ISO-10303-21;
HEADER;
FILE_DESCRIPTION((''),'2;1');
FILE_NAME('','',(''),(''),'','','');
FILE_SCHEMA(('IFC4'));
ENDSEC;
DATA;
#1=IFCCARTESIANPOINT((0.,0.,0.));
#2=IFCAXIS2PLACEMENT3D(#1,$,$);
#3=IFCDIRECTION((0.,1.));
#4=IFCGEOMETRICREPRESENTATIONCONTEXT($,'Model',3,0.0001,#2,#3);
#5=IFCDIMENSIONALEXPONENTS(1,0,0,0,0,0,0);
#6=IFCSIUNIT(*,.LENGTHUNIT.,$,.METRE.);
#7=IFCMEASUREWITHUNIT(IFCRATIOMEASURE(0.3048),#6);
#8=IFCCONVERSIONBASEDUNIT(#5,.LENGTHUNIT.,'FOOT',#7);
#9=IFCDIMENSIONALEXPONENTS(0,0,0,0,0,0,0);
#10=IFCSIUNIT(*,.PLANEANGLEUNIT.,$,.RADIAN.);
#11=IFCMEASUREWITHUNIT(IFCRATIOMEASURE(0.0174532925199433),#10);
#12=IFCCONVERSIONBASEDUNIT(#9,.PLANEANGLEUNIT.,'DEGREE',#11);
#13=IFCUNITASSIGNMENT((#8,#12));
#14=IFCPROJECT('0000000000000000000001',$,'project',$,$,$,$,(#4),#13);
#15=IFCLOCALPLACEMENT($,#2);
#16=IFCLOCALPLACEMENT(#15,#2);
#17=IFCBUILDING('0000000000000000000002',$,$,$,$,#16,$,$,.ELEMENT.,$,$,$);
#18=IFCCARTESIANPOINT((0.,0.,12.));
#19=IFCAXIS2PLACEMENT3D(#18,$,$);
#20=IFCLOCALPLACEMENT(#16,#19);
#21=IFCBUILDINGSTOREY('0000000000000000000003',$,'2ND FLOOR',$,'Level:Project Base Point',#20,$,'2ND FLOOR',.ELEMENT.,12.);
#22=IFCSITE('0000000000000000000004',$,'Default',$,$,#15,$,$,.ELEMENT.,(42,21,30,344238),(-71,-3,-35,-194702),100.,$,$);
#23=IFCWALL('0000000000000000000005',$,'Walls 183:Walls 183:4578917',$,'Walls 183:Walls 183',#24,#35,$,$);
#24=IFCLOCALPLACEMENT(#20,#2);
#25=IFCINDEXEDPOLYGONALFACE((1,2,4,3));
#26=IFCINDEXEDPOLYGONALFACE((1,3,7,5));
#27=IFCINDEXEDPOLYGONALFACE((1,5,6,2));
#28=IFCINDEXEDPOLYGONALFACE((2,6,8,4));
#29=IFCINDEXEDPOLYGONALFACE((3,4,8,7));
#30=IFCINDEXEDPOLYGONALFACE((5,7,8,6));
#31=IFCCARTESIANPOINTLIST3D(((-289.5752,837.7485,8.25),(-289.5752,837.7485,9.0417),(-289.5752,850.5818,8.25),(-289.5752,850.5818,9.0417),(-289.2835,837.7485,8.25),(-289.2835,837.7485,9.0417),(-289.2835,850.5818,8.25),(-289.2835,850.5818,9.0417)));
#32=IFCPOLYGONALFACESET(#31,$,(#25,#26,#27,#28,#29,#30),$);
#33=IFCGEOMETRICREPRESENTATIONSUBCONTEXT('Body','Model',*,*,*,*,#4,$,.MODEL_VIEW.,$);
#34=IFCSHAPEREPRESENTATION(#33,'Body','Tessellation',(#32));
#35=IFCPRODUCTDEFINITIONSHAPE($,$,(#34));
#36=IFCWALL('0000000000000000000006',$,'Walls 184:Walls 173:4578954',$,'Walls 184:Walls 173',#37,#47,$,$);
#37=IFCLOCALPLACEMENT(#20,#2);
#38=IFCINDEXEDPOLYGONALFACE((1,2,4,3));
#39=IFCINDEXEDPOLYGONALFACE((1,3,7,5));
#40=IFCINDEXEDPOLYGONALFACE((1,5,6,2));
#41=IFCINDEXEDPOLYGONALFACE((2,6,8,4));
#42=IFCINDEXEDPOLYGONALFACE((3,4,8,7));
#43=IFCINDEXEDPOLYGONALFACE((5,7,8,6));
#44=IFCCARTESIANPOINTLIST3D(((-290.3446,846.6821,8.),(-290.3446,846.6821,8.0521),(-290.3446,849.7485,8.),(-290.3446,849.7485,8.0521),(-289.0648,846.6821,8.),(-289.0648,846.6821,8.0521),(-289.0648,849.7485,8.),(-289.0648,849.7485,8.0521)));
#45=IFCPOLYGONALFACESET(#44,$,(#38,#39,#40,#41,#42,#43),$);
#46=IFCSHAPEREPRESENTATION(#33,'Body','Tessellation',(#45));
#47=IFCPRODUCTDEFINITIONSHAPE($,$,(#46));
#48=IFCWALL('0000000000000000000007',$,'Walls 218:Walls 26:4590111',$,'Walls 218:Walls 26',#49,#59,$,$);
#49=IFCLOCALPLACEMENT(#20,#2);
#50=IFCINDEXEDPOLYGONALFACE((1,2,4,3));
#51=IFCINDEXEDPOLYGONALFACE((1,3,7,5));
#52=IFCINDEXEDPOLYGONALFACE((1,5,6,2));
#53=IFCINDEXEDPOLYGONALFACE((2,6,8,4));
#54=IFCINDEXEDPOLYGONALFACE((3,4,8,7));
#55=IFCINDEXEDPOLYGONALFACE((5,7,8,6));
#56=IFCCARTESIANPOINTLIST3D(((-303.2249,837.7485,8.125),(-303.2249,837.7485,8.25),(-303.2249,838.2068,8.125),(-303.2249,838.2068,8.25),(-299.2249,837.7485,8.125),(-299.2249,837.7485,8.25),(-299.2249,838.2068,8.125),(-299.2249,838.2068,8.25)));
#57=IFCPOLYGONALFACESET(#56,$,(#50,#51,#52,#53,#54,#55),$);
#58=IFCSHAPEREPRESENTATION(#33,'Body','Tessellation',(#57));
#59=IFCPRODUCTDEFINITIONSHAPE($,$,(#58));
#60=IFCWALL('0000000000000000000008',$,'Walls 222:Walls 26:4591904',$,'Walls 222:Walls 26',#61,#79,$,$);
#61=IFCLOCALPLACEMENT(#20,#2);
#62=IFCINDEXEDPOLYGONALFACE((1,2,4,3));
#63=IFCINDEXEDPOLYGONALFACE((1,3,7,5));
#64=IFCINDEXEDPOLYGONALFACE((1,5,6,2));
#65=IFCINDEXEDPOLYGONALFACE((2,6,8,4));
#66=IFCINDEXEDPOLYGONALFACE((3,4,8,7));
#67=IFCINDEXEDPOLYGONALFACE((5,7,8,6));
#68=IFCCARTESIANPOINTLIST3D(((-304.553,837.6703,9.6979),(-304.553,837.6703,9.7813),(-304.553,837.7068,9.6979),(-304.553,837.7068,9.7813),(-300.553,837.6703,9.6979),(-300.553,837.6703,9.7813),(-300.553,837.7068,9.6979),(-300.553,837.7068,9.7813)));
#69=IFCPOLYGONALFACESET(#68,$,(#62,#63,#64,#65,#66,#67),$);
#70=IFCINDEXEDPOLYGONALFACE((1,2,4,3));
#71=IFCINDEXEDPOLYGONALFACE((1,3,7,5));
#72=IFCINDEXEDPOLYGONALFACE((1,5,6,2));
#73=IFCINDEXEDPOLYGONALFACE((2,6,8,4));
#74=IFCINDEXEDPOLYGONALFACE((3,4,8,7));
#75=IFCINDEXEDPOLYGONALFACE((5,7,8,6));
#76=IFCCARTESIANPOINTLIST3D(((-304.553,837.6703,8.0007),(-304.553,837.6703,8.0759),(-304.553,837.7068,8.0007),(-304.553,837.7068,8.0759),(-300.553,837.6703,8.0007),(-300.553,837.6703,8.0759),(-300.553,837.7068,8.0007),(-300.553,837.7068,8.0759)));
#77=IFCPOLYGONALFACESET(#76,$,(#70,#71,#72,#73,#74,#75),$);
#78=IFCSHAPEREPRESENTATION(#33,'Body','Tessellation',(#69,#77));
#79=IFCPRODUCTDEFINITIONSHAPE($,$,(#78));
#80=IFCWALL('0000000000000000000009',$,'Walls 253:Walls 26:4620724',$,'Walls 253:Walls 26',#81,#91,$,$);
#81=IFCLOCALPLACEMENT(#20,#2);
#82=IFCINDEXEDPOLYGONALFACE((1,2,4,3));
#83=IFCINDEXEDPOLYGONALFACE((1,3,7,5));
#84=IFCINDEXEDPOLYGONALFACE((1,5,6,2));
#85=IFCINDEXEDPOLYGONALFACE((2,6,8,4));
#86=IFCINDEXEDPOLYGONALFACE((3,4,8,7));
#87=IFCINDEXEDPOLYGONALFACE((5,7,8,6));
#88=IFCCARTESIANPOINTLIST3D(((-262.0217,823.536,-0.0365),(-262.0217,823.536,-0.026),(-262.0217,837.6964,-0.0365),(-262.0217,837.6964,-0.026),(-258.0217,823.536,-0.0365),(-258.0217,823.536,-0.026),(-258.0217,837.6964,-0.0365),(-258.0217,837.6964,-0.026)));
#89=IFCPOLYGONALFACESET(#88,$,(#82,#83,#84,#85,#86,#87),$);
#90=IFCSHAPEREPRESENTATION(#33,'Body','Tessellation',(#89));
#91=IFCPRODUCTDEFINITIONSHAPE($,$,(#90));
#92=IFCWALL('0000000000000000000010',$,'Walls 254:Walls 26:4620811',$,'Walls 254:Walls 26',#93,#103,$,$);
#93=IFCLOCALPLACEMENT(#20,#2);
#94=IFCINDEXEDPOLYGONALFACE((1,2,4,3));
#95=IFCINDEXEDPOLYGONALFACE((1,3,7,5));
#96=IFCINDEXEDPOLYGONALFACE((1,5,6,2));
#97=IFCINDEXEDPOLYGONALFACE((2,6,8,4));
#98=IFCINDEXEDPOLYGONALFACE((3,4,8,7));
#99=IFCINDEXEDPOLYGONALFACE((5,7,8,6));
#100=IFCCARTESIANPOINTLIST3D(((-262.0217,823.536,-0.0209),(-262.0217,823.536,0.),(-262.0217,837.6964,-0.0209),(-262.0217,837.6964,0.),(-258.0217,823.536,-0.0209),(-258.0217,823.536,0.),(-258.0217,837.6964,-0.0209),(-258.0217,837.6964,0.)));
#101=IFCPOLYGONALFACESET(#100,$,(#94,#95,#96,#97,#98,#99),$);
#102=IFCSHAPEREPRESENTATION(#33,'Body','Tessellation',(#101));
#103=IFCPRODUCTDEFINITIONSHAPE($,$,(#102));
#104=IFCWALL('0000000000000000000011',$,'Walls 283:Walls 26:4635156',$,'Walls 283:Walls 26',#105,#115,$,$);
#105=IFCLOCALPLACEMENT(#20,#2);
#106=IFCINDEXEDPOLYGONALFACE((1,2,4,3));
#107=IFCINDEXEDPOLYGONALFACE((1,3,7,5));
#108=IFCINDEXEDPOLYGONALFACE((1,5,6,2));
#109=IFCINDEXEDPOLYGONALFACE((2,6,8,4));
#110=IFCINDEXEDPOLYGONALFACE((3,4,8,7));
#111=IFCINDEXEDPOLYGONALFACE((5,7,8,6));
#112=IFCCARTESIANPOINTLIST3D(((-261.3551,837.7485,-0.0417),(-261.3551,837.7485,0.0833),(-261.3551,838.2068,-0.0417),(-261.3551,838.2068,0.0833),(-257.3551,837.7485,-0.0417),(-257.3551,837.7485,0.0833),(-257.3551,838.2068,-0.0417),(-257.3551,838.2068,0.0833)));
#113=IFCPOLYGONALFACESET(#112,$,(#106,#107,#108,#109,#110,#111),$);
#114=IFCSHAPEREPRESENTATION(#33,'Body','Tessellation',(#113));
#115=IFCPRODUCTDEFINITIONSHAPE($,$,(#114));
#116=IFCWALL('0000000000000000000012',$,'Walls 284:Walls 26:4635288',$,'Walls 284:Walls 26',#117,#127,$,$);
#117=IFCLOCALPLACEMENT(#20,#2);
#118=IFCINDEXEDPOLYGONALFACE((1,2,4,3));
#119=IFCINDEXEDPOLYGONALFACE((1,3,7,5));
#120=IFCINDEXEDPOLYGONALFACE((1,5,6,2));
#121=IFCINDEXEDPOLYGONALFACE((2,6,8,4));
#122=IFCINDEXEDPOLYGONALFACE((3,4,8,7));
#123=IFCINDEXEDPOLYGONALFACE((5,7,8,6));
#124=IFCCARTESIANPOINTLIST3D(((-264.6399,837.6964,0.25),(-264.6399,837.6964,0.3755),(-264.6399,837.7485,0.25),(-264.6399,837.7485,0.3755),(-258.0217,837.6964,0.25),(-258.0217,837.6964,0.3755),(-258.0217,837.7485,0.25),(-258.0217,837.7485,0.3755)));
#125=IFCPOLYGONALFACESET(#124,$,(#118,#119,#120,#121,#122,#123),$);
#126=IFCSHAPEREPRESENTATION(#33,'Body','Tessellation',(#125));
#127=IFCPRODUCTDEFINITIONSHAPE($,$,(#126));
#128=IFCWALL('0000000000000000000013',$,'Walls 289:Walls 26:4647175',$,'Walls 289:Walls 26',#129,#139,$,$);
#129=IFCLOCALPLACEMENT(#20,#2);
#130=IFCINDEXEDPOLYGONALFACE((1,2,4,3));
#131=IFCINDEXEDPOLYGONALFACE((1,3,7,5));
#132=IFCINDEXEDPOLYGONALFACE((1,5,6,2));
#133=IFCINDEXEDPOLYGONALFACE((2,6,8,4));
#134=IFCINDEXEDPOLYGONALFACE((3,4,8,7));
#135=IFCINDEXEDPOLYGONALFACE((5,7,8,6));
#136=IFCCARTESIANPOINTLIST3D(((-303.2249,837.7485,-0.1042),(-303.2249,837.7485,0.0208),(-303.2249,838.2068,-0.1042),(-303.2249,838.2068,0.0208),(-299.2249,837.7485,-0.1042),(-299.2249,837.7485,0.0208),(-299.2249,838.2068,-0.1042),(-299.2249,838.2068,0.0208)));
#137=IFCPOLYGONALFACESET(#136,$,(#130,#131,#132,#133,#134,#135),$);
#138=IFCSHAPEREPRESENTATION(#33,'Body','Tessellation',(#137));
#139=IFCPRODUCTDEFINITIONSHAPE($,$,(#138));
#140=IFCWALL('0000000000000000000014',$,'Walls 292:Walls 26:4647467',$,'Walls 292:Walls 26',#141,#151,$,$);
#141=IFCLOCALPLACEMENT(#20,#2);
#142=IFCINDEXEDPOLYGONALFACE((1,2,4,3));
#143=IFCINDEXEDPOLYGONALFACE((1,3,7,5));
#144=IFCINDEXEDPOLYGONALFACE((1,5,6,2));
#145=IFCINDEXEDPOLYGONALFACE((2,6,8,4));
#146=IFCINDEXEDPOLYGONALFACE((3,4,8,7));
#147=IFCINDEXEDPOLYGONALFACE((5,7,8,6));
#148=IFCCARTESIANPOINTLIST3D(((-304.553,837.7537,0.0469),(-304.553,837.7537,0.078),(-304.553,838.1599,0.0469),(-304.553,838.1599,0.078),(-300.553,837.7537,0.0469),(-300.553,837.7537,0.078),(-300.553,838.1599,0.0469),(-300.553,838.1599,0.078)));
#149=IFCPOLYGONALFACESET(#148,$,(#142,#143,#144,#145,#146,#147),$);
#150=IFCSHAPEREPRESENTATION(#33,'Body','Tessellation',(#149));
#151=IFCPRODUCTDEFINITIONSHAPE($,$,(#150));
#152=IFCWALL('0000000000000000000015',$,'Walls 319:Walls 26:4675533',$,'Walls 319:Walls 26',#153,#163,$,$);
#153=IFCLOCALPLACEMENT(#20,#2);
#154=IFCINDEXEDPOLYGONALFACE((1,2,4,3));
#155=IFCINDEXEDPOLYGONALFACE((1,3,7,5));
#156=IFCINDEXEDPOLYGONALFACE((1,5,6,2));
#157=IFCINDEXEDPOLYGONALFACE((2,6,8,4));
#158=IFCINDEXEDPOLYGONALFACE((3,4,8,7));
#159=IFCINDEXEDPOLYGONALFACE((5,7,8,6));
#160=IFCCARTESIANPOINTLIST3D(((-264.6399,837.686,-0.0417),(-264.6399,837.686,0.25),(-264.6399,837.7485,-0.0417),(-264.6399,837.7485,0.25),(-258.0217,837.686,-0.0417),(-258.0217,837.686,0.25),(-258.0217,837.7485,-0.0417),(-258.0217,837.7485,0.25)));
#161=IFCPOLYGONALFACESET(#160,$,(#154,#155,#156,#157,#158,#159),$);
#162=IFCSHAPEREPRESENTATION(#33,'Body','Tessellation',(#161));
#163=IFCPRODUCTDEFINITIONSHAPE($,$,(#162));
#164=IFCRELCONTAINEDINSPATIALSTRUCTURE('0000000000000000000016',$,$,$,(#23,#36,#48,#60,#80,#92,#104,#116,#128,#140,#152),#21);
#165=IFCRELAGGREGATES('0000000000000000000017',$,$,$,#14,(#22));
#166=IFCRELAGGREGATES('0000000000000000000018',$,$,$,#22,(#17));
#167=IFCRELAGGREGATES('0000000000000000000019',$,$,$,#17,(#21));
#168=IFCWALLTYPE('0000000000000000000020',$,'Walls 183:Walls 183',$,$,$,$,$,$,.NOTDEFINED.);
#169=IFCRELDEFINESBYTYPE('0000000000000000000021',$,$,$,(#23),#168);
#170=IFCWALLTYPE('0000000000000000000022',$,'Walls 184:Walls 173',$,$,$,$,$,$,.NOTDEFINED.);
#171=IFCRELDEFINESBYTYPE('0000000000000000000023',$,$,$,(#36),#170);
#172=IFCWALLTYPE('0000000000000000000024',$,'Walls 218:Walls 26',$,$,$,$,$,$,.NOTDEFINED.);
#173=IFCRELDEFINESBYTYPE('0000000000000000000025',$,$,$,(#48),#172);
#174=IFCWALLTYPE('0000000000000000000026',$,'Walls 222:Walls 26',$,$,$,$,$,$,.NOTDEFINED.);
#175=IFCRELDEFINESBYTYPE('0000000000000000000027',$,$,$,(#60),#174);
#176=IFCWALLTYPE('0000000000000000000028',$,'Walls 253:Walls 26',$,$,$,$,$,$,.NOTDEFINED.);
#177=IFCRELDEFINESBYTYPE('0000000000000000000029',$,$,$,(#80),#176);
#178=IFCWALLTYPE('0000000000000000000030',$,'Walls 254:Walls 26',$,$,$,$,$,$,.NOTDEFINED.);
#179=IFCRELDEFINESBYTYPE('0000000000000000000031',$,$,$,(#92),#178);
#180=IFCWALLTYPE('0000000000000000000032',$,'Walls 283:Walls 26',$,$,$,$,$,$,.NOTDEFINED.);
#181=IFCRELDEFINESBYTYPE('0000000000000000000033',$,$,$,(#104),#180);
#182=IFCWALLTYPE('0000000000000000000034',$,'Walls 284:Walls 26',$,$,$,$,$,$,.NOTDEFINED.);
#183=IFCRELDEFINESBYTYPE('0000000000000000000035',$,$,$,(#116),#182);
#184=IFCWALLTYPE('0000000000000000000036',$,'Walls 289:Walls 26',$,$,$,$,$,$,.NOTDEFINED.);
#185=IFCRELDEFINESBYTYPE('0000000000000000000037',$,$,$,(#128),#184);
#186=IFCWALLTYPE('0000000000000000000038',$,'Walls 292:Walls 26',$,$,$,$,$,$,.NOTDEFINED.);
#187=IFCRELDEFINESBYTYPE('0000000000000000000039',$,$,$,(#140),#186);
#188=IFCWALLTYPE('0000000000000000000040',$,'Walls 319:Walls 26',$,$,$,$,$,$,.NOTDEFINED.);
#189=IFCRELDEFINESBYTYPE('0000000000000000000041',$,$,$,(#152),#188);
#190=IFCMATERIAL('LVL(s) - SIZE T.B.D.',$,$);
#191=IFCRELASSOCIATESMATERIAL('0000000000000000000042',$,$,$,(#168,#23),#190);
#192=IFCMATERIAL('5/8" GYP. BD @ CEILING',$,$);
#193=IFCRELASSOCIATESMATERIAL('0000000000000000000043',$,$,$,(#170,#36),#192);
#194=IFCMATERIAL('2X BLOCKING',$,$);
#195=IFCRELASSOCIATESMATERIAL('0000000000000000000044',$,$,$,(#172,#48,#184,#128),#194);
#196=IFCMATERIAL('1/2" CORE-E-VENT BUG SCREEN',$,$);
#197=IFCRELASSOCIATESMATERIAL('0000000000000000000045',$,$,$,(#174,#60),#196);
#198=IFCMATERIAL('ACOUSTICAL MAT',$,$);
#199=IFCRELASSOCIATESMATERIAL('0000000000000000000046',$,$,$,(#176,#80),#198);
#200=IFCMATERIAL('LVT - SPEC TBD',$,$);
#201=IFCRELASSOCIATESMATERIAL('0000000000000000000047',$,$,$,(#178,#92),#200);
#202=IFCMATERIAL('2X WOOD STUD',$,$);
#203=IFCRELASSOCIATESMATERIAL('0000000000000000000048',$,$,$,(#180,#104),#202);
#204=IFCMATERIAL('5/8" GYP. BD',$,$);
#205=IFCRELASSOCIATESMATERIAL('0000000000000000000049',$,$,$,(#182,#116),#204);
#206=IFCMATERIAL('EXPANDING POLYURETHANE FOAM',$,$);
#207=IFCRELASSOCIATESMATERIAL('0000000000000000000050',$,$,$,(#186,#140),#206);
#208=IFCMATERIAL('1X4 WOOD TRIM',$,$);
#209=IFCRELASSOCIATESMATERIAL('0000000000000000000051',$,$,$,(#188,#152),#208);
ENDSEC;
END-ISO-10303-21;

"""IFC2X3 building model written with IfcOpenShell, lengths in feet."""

from ifc_helpers import new_model, entity, si_unit, converted_unit, direction, frame, frame_2d, origin, origin_2d_with_axis, place, context, subcontext, project, spatial, rectangle, extrude, material, type_object, element, save


model = new_model("IFC2X3")

# Units and contexts
model_context = context("Model", 3, precision=0.0001, world=origin(), true_north=direction((0.0, 1.0)))
body_context = subcontext(model_context, "Body", "Model", "MODEL_VIEW")
ifc_project = project(units=[converted_unit("LENGTHUNIT", "FOOT", entity("IfcRatioMeasure", 0.3048), si_unit("LENGTHUNIT", "METRE"), dimensions=[1, 0, 0, 0, 0, 0, 0]), converted_unit("PLANEANGLEUNIT", "DEGREE", entity("IfcRatioMeasure", 0.0174532925199433), si_unit("PLANEANGLEUNIT", "RADIAN"), dimensions=[0, 0, 0, 0, 0, 0, 0])], contexts=[model_context])

# Site, building, storey
site_placement = place(None, origin())
site = spatial("IfcSite", under=ifc_project, at=site_placement, Name="Default", CompositionType="ELEMENT", RefLatitude=(42, 21, 30, 344238), RefLongitude=(-71, -3, -35, -194702), RefElevation=100.0)
building_placement = place(site_placement, origin())
building = spatial("IfcBuilding", under=site, at=building_placement, CompositionType="ELEMENT")
storey_placement = place(building_placement, frame((0.0, 0.0, 12.0)))
storey = spatial("IfcBuildingStorey", under=building, at=storey_placement, Name="2ND FLOOR", ObjectType="Level:Project Base Point", LongName="2ND FLOOR", CompositionType="ELEMENT", Elevation=12.0)

# Walls
ifc_material_1 = material(Name="EXPANDING POLYURETHANE FOAM")
ifc_material_2 = material(Name="LVL(s) - SIZE T.B.D.")
ifc_material_3 = material(Name="2X BLOCKING")
wall_type_1 = type_object("IfcWallType", Name="Walls 183:Walls 183", PredefinedType="NOTDEFINED", material=ifc_material_2)
wall_1_placement = place(storey_placement, frame((-289.5752, 837.7485, 8.25), z_axis=(0.0, 0.0, 1.0), x_axis=(0.0, 1.0, 0.0)))
element("IfcWall", 1, at=wall_1_placement, inside=storey, type_object=wall_type_1, material=ifc_material_2, Name="Walls 183:Walls 183:4578917", ObjectType="Walls 183:Walls 183", context=body_context, shape_type="SweptSolid", body=[
    extrude(rectangle(XDim=12.8333, YDim=0.2917, at=frame_2d((0.0, 0.0), x_axis=(1.0, 0.0))), frame((6.4167, -0.1458, 0.0)), (0.0, 0.0, 1.0), 0.7917),
])
ifc_material_4 = material(Name="5/8\" GYP. BD @ CEILING")
wall_type_2 = type_object("IfcWallType", Name="Walls 184:Walls 173", PredefinedType="NOTDEFINED", material=ifc_material_4)
wall_2_placement = place(storey_placement, frame((-290.3446, 846.6821, 8.0), z_axis=(0.0, 0.0, 1.0), x_axis=(0.0, 1.0, 0.0)))
element("IfcWall", 2, at=wall_2_placement, inside=storey, type_object=wall_type_2, material=ifc_material_4, Name="Walls 184:Walls 173:4578954", ObjectType="Walls 184:Walls 173", context=body_context, shape_type="SweptSolid", body=[
    extrude(rectangle(XDim=1.2799, YDim=3.0664, at=frame_2d((0.0, 0.0), x_axis=(1.0, 0.0))), frame((1.5332, -0.6399, 0.0), z_axis=(0.0, 0.0, 1.0), x_axis=(0.0, -1.0, 0.0)), (0.0, 0.0, 1.0), 0.0521),
])
wall_type_3 = type_object("IfcWallType", Name="Walls 218:Walls 26", PredefinedType="NOTDEFINED", material=ifc_material_3)
wall_3_placement = place(storey_placement, frame((-303.2249, 837.7485, 8.125)))
element("IfcWall", 3, at=wall_3_placement, inside=storey, type_object=wall_type_3, material=ifc_material_3, Name="Walls 218:Walls 26:4590111", ObjectType="Walls 218:Walls 26", context=body_context, shape_type="SweptSolid", body=[
    extrude(rectangle(XDim=4.0, YDim=0.4583, at=origin_2d_with_axis()), frame((2.0, 0.2292, 0.0), z_axis=(0.0, 0.0, 1.0), x_axis=(-1.0, 0.0, 0.0)), (0.0, 0.0, 1.0), 0.125),
])
ifc_material_5 = material(Name="1/2\" CORE-E-VENT BUG SCREEN")
wall_type_4 = type_object("IfcWallType", Name="Walls 222:Walls 26", PredefinedType="NOTDEFINED", material=ifc_material_5)
wall_4_placement = place(storey_placement, frame((-304.553, 837.6703, 8.0007)))
element("IfcWall", 4, at=wall_4_placement, inside=storey, type_object=wall_type_4, material=ifc_material_5, Name="Walls 222:Walls 26:4591904", ObjectType="Walls 222:Walls 26", context=body_context, shape_type="SweptSolid", body=[
    extrude(rectangle(XDim=4.0, YDim=0.0365, at=origin_2d_with_axis()), frame((2.0, 0.0182, 1.6973), z_axis=(0.0, 0.0, 1.0), x_axis=(-1.0, 0.0, 0.0)), (0.0, 0.0, 1.0), 0.0833),
    extrude(rectangle(XDim=4.0, YDim=0.0365, at=origin_2d_with_axis()), frame((2.0, 0.0182, 0.0), z_axis=(0.0, 0.0, 1.0), x_axis=(-1.0, 0.0, 0.0)), (0.0, 0.0, 1.0), 0.0753),
])
ifc_material_6 = material(Name="ACOUSTICAL MAT")
wall_type_5 = type_object("IfcWallType", Name="Walls 253:Walls 26", PredefinedType="NOTDEFINED", material=ifc_material_6)
wall_5_placement = place(storey_placement, frame((-262.0217, 823.536, -0.0365), z_axis=(0.0, 0.0, 1.0), x_axis=(0.0, 1.0, 0.0)))
element("IfcWall", 5, at=wall_5_placement, inside=storey, type_object=wall_type_5, material=ifc_material_6, Name="Walls 253:Walls 26:4620724", ObjectType="Walls 253:Walls 26", context=body_context, shape_type="SweptSolid", body=[
    extrude(rectangle(XDim=4.0, YDim=14.1604, at=frame_2d((0.0, 0.0), x_axis=(1.0, 0.0))), frame((7.0802, -2.0, 0.0), z_axis=(0.0, 0.0, 1.0), x_axis=(0.0, 1.0, 0.0)), (0.0, 0.0, 1.0), 0.0104),
])
ifc_material_7 = material(Name="LVT - SPEC TBD")
wall_type_6 = type_object("IfcWallType", Name="Walls 254:Walls 26", PredefinedType="NOTDEFINED", material=ifc_material_7)
wall_6_placement = place(storey_placement, frame((-262.0217, 823.536, -0.0209), z_axis=(0.0, 0.0, 1.0), x_axis=(0.0, 1.0, 0.0)))
element("IfcWall", 6, at=wall_6_placement, inside=storey, type_object=wall_type_6, material=ifc_material_7, Name="Walls 254:Walls 26:4620811", ObjectType="Walls 254:Walls 26", context=body_context, shape_type="SweptSolid", body=[
    extrude(rectangle(XDim=4.0, YDim=14.1604, at=origin_2d_with_axis()), frame((7.0802, -2.0, 0.0), z_axis=(0.0, 0.0, 1.0), x_axis=(0.0, 1.0, 0.0)), (0.0, 0.0, 1.0), 0.0208),
])
ifc_material_8 = material(Name="2X WOOD STUD")
wall_type_7 = type_object("IfcWallType", Name="Walls 283:Walls 26", PredefinedType="NOTDEFINED", material=ifc_material_8)
wall_7_placement = place(storey_placement, frame((-261.3551, 837.7485, -0.0417)))
element("IfcWall", 7, at=wall_7_placement, inside=storey, type_object=wall_type_7, material=ifc_material_8, Name="Walls 283:Walls 26:4635156", ObjectType="Walls 283:Walls 26", context=body_context, shape_type="SweptSolid", body=[
    extrude(rectangle(XDim=4.0, YDim=0.4583, at=frame_2d((0.0, 0.0), x_axis=(1.0, 0.0))), frame((2.0, 0.2292, 0.0), z_axis=(0.0, 0.0, 1.0), x_axis=(-1.0, 0.0, 0.0)), (0.0, 0.0, 1.0), 0.125),
])
ifc_material_9 = material(Name="5/8\" GYP. BD")
wall_type_8 = type_object("IfcWallType", Name="Walls 284:Walls 26", PredefinedType="NOTDEFINED", material=ifc_material_9)
wall_8_placement = place(storey_placement, frame((-264.6399, 837.6964, 0.25)))
element("IfcWall", 8, at=wall_8_placement, inside=storey, type_object=wall_type_8, material=ifc_material_9, Name="Walls 284:Walls 26:4635288", ObjectType="Walls 284:Walls 26", context=body_context, shape_type="SweptSolid", body=[
    extrude(rectangle(XDim=6.6181, YDim=0.0521, at=frame_2d((0.0, 0.0), x_axis=(1.0, 0.0))), frame((3.3091, 0.026, 0.0), z_axis=(0.0, 0.0, 1.0), x_axis=(-1.0, 0.0, 0.0)), (0.0, 0.0, 1.0), 0.1255),
])
wall_type_9 = type_object("IfcWallType", Name="Walls 289:Walls 26", PredefinedType="NOTDEFINED", material=ifc_material_3)
wall_9_placement = place(storey_placement, frame((-303.2249, 837.7485, -0.1042)))
element("IfcWall", 9, at=wall_9_placement, inside=storey, type_object=wall_type_9, material=ifc_material_3, Name="Walls 289:Walls 26:4647175", ObjectType="Walls 289:Walls 26", context=body_context, shape_type="SweptSolid", body=[
    extrude(rectangle(XDim=4.0, YDim=0.4583, at=origin_2d_with_axis()), frame((2.0, 0.2292, 0.0), z_axis=(0.0, 0.0, 1.0), x_axis=(-1.0, 0.0, 0.0)), (0.0, 0.0, 1.0), 0.125),
])
wall_type_10 = type_object("IfcWallType", Name="Walls 292:Walls 26", PredefinedType="NOTDEFINED", material=ifc_material_1)
wall_10_placement = place(storey_placement, frame((-304.553, 837.7537, 0.0469)))
element("IfcWall", 10, at=wall_10_placement, inside=storey, type_object=wall_type_10, material=ifc_material_1, Name="Walls 292:Walls 26:4647467", ObjectType="Walls 292:Walls 26", context=body_context, shape_type="SweptSolid", body=[
    extrude(rectangle(XDim=4.0, YDim=0.4062, at=origin_2d_with_axis()), frame((2.0, 0.2031, 0.0), z_axis=(0.0, 0.0, 1.0), x_axis=(-1.0, 0.0, 0.0)), (0.0, 0.0, 1.0), 0.0311),
])
ifc_material_10 = material(Name="1X4 WOOD TRIM")
wall_type_11 = type_object("IfcWallType", Name="Walls 319:Walls 26", PredefinedType="NOTDEFINED", material=ifc_material_10)
wall_11_placement = place(storey_placement, frame((-264.6399, 837.686, -0.0417)))
element("IfcWall", 11, at=wall_11_placement, inside=storey, type_object=wall_type_11, material=ifc_material_10, Name="Walls 319:Walls 26:4675533", ObjectType="Walls 319:Walls 26", context=body_context, shape_type="SweptSolid", body=[
    extrude(rectangle(XDim=6.6181, YDim=0.0625, at=frame_2d((0.0, 0.0), x_axis=(1.0, 0.0))), frame((3.3091, 0.0312, 0.0), z_axis=(0.0, 0.0, 1.0), x_axis=(-1.0, 0.0, 0.0)), (0.0, 0.0, 1.0), 0.2917),
])

save(model, "model.ifc")
